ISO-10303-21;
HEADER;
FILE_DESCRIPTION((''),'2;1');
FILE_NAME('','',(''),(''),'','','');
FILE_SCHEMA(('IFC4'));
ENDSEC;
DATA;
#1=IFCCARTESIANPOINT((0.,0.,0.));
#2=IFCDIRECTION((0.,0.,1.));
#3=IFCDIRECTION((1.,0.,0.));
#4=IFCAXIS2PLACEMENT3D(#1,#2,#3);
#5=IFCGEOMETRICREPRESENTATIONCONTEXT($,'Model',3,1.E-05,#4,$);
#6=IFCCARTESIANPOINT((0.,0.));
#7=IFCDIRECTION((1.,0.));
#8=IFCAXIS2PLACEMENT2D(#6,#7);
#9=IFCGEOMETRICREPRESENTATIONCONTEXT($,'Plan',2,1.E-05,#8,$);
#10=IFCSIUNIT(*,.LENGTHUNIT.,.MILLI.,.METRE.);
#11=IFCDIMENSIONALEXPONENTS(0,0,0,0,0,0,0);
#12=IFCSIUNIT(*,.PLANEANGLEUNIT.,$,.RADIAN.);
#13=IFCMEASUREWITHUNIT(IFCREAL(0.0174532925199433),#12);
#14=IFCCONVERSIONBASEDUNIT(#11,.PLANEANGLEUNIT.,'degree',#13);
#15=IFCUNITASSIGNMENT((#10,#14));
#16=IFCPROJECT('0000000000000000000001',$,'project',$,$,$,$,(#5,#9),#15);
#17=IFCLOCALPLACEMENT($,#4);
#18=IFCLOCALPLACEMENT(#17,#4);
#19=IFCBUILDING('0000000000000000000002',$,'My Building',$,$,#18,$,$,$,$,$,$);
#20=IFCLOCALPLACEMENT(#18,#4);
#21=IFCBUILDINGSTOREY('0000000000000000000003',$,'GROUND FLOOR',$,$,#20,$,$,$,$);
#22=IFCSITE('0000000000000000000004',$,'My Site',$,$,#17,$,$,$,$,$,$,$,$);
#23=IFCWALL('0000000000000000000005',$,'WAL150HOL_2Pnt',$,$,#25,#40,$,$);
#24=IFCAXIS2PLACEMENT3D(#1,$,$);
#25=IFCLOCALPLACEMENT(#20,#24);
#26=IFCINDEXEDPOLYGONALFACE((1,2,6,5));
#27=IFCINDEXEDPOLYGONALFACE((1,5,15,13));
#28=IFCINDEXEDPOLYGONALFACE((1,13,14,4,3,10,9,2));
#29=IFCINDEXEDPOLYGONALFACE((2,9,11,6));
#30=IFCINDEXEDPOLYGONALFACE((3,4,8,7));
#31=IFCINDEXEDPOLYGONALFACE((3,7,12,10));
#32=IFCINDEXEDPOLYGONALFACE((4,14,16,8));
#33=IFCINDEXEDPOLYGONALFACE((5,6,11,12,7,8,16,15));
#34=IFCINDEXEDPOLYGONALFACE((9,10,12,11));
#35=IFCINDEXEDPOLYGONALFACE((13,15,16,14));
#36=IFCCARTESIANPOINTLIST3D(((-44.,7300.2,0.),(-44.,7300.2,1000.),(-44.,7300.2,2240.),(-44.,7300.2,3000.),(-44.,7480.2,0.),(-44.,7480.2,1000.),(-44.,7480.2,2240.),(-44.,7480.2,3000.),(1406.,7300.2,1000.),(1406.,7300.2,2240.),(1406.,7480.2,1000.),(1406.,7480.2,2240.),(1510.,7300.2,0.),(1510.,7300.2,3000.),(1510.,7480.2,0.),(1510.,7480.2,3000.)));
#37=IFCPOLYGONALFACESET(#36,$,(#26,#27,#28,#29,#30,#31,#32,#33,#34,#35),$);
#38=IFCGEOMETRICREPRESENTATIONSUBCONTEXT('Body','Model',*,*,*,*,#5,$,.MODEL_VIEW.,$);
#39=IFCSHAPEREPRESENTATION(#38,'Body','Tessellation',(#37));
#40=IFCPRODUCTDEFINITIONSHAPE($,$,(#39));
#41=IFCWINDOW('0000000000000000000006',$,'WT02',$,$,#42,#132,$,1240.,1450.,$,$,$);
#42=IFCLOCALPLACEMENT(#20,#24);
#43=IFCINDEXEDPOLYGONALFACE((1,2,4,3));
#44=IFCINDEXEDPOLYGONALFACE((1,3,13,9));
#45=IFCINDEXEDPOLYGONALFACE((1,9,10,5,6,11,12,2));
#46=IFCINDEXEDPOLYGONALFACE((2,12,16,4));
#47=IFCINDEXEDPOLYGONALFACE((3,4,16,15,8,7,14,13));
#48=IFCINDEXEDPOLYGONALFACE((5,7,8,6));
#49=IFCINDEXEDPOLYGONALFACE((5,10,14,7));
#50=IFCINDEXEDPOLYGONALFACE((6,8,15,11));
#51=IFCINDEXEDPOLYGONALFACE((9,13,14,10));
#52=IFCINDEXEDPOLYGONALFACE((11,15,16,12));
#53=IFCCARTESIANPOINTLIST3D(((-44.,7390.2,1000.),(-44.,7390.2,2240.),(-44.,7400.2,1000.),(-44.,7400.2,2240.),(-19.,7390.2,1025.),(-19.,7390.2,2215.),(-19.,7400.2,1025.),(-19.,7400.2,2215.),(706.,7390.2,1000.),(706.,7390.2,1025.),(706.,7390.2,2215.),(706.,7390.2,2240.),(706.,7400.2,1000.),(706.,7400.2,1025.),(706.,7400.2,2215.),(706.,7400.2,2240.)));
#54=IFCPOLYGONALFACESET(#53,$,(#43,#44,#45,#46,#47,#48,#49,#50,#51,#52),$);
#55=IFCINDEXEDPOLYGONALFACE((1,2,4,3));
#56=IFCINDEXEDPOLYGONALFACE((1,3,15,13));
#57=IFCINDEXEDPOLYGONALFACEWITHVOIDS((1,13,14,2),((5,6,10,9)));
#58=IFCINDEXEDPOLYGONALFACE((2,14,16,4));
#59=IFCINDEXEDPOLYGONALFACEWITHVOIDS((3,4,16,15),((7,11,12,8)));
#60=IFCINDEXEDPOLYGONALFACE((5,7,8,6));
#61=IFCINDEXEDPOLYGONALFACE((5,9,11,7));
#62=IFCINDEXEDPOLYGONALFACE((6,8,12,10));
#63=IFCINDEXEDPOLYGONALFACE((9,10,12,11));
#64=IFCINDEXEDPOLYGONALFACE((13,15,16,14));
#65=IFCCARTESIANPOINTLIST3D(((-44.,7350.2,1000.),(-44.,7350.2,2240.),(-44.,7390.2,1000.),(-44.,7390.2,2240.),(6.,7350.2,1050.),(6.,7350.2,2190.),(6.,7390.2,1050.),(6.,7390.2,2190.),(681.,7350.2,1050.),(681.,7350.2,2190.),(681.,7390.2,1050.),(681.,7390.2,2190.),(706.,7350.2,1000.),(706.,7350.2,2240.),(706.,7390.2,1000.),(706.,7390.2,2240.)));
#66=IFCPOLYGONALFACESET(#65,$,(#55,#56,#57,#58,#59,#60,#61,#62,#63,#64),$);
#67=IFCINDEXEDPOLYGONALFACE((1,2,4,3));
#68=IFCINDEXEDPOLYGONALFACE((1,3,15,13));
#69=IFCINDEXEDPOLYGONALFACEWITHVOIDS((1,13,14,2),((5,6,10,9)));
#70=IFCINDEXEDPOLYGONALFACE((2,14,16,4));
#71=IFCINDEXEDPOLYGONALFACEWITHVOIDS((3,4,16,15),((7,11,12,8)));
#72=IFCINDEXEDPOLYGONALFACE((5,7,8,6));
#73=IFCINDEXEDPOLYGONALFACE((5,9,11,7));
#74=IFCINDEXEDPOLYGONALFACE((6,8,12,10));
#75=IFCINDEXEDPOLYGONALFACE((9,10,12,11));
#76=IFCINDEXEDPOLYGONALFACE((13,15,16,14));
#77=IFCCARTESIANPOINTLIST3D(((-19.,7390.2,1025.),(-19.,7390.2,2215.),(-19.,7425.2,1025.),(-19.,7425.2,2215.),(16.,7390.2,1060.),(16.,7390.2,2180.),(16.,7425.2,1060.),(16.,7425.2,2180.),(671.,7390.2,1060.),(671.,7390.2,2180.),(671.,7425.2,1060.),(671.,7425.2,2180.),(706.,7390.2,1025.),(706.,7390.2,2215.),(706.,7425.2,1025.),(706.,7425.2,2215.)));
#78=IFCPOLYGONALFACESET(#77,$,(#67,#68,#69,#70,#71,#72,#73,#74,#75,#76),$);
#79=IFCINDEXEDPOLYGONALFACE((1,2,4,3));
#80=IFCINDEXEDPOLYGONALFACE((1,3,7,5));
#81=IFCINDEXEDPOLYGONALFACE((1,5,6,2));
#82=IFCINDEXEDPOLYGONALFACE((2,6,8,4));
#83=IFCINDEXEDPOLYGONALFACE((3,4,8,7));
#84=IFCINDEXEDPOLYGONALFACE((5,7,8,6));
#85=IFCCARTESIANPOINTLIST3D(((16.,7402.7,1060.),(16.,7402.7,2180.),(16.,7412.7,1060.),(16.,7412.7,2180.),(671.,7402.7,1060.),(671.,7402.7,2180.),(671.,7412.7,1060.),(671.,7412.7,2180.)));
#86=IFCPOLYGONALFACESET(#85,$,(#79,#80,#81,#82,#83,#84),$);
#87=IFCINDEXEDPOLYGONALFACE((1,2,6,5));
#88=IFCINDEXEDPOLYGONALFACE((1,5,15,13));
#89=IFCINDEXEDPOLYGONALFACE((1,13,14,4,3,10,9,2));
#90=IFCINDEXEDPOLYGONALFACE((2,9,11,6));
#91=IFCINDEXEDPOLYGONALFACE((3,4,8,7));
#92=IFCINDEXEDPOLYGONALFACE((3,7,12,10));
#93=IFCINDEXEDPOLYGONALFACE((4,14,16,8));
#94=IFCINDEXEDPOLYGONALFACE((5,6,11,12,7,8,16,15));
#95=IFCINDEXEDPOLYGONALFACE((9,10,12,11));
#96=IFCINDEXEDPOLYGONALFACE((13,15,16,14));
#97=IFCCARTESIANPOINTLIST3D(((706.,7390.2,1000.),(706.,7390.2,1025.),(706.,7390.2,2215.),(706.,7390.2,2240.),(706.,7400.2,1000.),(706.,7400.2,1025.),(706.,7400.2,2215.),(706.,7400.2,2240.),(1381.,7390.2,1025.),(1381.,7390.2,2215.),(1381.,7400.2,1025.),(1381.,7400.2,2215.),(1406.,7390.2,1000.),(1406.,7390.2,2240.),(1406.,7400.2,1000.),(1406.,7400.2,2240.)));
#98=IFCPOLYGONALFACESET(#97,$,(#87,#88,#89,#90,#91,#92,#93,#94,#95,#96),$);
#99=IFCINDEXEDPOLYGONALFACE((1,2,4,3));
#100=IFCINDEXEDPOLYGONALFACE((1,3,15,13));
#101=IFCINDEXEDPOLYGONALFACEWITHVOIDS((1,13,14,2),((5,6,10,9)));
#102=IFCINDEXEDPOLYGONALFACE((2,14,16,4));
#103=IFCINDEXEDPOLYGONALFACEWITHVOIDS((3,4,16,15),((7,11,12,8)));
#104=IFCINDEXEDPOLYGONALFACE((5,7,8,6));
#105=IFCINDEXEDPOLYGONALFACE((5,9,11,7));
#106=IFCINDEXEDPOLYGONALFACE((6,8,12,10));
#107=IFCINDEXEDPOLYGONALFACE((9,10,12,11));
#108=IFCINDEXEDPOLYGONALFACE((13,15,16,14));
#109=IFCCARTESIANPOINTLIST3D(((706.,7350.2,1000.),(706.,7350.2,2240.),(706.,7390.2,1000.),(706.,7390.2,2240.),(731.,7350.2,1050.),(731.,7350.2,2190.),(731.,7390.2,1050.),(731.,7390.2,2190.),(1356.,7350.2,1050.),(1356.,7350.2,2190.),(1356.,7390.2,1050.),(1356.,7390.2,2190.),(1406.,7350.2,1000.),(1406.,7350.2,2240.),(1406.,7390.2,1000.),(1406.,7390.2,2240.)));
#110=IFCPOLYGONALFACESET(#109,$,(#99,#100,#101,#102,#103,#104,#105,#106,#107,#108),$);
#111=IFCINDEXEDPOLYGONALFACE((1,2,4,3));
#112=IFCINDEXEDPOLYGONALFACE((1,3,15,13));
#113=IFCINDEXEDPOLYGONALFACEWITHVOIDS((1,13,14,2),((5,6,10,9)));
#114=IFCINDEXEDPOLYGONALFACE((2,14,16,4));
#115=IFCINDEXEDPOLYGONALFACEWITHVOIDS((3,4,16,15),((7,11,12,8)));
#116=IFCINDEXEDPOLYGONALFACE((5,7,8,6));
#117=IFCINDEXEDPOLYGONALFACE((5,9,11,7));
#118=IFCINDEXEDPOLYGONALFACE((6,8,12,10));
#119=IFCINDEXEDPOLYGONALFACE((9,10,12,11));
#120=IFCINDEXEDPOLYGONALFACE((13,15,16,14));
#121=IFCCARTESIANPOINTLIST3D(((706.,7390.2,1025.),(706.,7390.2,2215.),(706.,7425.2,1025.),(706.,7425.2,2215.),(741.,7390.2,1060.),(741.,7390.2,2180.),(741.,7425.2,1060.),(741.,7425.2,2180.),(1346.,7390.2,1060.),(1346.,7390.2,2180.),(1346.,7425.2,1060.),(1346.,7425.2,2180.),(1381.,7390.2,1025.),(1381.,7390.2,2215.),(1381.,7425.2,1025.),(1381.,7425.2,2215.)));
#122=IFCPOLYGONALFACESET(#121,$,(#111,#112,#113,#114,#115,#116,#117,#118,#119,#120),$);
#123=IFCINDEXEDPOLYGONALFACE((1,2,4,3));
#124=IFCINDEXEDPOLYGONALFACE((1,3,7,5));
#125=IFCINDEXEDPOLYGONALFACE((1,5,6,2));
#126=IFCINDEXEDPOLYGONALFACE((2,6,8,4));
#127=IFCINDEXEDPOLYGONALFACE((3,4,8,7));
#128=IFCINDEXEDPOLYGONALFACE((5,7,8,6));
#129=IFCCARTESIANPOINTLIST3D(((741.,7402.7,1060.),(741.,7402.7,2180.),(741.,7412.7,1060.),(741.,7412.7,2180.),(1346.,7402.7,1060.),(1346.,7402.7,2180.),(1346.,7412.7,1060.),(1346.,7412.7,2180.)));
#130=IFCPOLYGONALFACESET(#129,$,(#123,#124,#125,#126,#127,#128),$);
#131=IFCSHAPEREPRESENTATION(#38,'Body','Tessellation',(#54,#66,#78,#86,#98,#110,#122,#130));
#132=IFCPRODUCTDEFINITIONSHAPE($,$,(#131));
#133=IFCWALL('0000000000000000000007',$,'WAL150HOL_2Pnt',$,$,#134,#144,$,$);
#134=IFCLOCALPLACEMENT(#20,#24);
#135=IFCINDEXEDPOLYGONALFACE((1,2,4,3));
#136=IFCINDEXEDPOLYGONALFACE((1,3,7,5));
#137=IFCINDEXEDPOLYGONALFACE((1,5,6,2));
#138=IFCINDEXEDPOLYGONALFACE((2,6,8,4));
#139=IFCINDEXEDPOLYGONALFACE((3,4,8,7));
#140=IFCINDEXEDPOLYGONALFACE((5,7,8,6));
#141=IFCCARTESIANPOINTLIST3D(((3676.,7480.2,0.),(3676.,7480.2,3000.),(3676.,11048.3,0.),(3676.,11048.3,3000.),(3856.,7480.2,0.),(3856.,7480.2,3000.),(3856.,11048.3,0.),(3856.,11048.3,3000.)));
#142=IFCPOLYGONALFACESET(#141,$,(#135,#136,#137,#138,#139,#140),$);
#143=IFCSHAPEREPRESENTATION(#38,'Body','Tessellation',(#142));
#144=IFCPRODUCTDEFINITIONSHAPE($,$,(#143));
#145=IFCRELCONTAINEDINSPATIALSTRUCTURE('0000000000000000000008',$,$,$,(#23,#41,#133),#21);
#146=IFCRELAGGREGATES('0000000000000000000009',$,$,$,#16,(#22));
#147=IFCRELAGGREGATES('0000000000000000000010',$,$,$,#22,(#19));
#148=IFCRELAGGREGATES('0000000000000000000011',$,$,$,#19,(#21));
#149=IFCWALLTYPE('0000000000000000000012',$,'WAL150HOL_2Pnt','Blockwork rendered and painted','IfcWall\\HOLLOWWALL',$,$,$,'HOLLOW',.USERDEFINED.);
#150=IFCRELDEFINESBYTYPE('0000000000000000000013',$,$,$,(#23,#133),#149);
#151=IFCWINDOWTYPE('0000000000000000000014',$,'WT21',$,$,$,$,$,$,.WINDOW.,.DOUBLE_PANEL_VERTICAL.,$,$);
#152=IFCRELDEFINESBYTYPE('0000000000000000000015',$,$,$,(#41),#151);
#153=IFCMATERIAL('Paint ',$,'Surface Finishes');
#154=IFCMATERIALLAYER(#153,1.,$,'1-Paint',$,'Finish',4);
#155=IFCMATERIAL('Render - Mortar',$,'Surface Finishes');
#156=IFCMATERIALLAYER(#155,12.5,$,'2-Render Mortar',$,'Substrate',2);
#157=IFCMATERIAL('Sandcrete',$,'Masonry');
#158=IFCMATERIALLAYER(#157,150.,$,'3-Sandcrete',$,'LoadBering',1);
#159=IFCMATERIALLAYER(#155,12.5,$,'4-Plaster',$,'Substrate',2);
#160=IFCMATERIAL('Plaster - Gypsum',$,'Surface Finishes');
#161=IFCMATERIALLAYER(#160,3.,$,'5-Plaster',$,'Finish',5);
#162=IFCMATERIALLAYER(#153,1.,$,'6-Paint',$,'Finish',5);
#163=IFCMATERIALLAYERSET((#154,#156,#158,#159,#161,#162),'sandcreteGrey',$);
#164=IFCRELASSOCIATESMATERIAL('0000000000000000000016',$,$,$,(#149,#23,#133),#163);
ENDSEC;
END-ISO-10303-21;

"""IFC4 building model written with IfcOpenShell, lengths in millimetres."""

from ifc_helpers import new_model, entity, si_unit, converted_unit, frame, origin_with_axes, origin_2d_with_axis, place, context, subcontext, project, spatial, line, indexed_curve, outline, extrude, shape, source, transform, mapped, material, layer, layer_set, layer_usage, type_object, type_shapes, element, fill, save


model = new_model("IFC4")

# Units and contexts
model_context = context("Model", 3, precision=1e-05, world=origin_with_axes())
plan_context = context("Plan", 2, precision=1e-05, world=origin_2d_with_axis())
body_context_1 = subcontext(model_context, "Body", "Model", "MODEL_VIEW")
body_context_2 = subcontext(plan_context, "Body", "Plan", "PLAN_VIEW")
ifc_project = project(units=[si_unit("LENGTHUNIT", "METRE", prefix="MILLI"), converted_unit("PLANEANGLEUNIT", "degree", entity("IfcReal", 0.0174532925199433), si_unit("PLANEANGLEUNIT", "RADIAN"), dimensions=[0, 0, 0, 0, 0, 0, 0])], contexts=[model_context, plan_context])

# Site, building, storey
site_placement = place(None, origin_with_axes())
site = spatial("IfcSite", under=ifc_project, at=site_placement, Name="My Site")
building_placement = place(site_placement, origin_with_axes())
building = spatial("IfcBuilding", under=site, at=building_placement, Name="My Building")
storey_placement = place(building_placement, origin_with_axes())
storey = spatial("IfcBuildingStorey", under=building, at=storey_placement, Name="GROUND FLOOR")

# Wall, opening, window
ifc_material_1 = material(Name="Paint ", Category="Surface Finishes")
ifc_layer_1 = layer(ifc_material_1, 1.0, Name="1-Paint", Category="Finish", Priority=4)
ifc_material_2 = material(Name="Render - Mortar", Category="Surface Finishes")
ifc_layer_2 = layer(ifc_material_2, 12.5, Name="2-Render Mortar", Category="Substrate", Priority=2)
ifc_material_3 = material(Name="Sandcrete", Category="Masonry")
ifc_layer_3 = layer(ifc_material_3, 150.0, Name="3-Sandcrete", Category="LoadBering", Priority=1)
ifc_layer_4 = layer(ifc_material_2, 12.5, Name="4-Plaster", Category="Substrate", Priority=2)
ifc_material_4 = material(Name="Plaster - Gypsum", Category="Surface Finishes")
ifc_layer_5 = layer(ifc_material_4, 3.0, Name="5-Plaster", Category="Finish", Priority=5)
ifc_layer_6 = layer(ifc_material_1, 1.0, Name="6-Paint", Category="Finish", Priority=5)
ifc_layer_set_1 = layer_set([ifc_layer_1, ifc_layer_2, ifc_layer_3, ifc_layer_4, ifc_layer_5, ifc_layer_6], Name="sandcreteGrey")
ifc_layer_usage_1 = layer_usage(ifc_layer_set_1, "AXIS2", "POSITIVE", 0.0)
wall_type_1 = type_object("IfcWallType", Name="WAL150HOL_2Pnt", Description="Blockwork rendered and painted", ApplicableOccurrence="IfcWall\\HOLLOWWALL", ElementType="HOLLOW", PredefinedType="USERDEFINED", material=ifc_layer_set_1)
wall_1_placement = place(storey_placement, frame((-44.0, 7300.2, 0.0), z_axis=(0.0, 0.0, 1.0), x_axis=(1.0, 0.0, 0.0)))
wall_1 = element("IfcWall", 1, at=wall_1_placement, inside=storey, type_object=wall_type_1, material=ifc_layer_usage_1, Name="WAL150HOL_2Pnt", context=body_context_1, shape_type="SweptSolid", body=[
    extrude(outline(indexed_curve([(0.0, 0.0), (0.0, 180.0), (1554.0, 180.0), (1554.0, 0.0), (0.0, 0.0)], self_intersect=False)), origin_with_axes(), (0.0, 0.0, 1.0), 3000.0),
])
shared_shape_1 = source(origin_with_axes(), body_context_1, "Body", "SweptSolid", [
    extrude(outline(indexed_curve([(0.0, 0.0), (1450.0, 0.0), (1450.0, 1240.0), (0.0, 1240.0)], segments=[line(1, 2, 3, 4, 1)])), frame((0.0, -100.0, 0.0), z_axis=(0.0, -1.0, 0.0), x_axis=(1.0, 0.0, 0.0)), (0.0, 0.0, -1.0), 388.0),
])
opening_1_placement = place(wall_1_placement, frame((0.0, 0.0, 1000.0), z_axis=(0.0, 0.0, 1.0), x_axis=(1.0, 0.0, 0.0)))
opening_1 = element("IfcOpeningElement", 2, at=opening_1_placement, cuts=wall_1, PredefinedType="OPENING", context=body_context_1, shape_type="MappedRepresentation", body=[
    mapped(shared_shape_1, transform((0.0, 0.0, 0.0), x_axis=(1.0, 0.0, 0.0), y_axis=(0.0, 1.0, 0.0), z_axis=(0.0, 0.0, 1.0), scale=1.0)),
])
window_type_1 = type_object("IfcWindowType", Name="WT21", PartitioningType="DOUBLE_PANEL_VERTICAL", PredefinedType="WINDOW")
shared_shape_2 = source(origin_with_axes(), body_context_1, "Body", "SweptSolid", [
    extrude(outline(indexed_curve([(750.0, 0.0), (0.0, 0.0), (0.0, 1240.0), (750.0, 1240.0), (750.0, 1215.0), (25.0, 1215.0), (25.0, 25.0), (750.0, 25.0)], segments=[line(1, 2, 3, 4, 5, 6, 7, 8, 1)])), frame((0.0, 90.0, 0.0), z_axis=(0.0, -1.0, 0.0), x_axis=(1.0, 0.0, 0.0)), (0.0, 0.0, -1.0), 10.0),
    extrude(outline(indexed_curve([(0.0, 0.0), (750.0, 0.0), (750.0, 1240.0), (0.0, 1240.0)], segments=[line(1, 2, 3, 4, 1)]), holes=[indexed_curve([(50.0, 50.0), (725.0, 50.0), (725.0, 1190.0), (50.0, 1190.0)], segments=[line(1, 2, 3, 4, 1)])]), frame((0.0, 50.0, 0.0), z_axis=(0.0, -1.0, 0.0), x_axis=(1.0, 0.0, 0.0)), (0.0, 0.0, -1.0), 40.0),
    extrude(outline(indexed_curve([(0.0, 0.0), (725.0, 0.0), (725.0, 1190.0), (0.0, 1190.0)], segments=[line(1, 2, 3, 4, 1)]), holes=[indexed_curve([(35.0, 35.0), (690.0, 35.0), (690.0, 1155.0), (35.0, 1155.0)], segments=[line(1, 2, 3, 4, 1)])]), frame((25.0, 90.0, 25.0), z_axis=(0.0, -1.0, 0.0), x_axis=(1.0, 0.0, 0.0)), (0.0, 0.0, -1.0), 35.0),
    extrude(outline(indexed_curve([(35.0, 35.0), (690.0, 35.0), (690.0, 1155.0), (35.0, 1155.0)], segments=[line(1, 2, 3, 4, 1)])), frame((25.0, 102.5, 25.0), z_axis=(0.0, -1.0, 0.0), x_axis=(1.0, 0.0, 0.0)), (0.0, 0.0, -1.0), 10.0),
    extrude(outline(indexed_curve([(0.0, 1240.0), (700.0, 1240.0), (700.0, 0.0), (0.0, 0.0), (0.0, 25.0), (675.0, 25.0), (675.0, 1215.0), (0.0, 1215.0)], segments=[line(1, 2, 3, 4, 5, 6, 7, 8, 1)])), frame((750.0, 90.0, 0.0), z_axis=(0.0, -1.0, 0.0), x_axis=(1.0, 0.0, 0.0)), (0.0, 0.0, -1.0), 10.0),
    extrude(outline(indexed_curve([(0.0, 0.0), (700.0, 0.0), (700.0, 1240.0), (0.0, 1240.0)], segments=[line(1, 2, 3, 4, 1)]), holes=[indexed_curve([(25.0, 50.0), (650.0, 50.0), (650.0, 1190.0), (25.0, 1190.0)], segments=[line(1, 2, 3, 4, 1)])]), frame((750.0, 50.0, 0.0), z_axis=(0.0, -1.0, 0.0), x_axis=(1.0, 0.0, 0.0)), (0.0, 0.0, -1.0), 40.0),
    extrude(outline(indexed_curve([(0.0, 0.0), (675.0, 0.0), (675.0, 1190.0), (0.0, 1190.0)], segments=[line(1, 2, 3, 4, 1)]), holes=[indexed_curve([(35.0, 35.0), (640.0, 35.0), (640.0, 1155.0), (35.0, 1155.0)], segments=[line(1, 2, 3, 4, 1)])]), frame((750.0, 90.0, 25.0), z_axis=(0.0, -1.0, 0.0), x_axis=(1.0, 0.0, 0.0)), (0.0, 0.0, -1.0), 35.0),
    extrude(outline(indexed_curve([(35.0, 35.0), (640.0, 35.0), (640.0, 1155.0), (35.0, 1155.0)], segments=[line(1, 2, 3, 4, 1)])), frame((750.0, 102.5, 25.0), z_axis=(0.0, -1.0, 0.0), x_axis=(1.0, 0.0, 0.0)), (0.0, 0.0, -1.0), 10.0),
])
shared_shape_3 = source(origin_with_axes(), body_context_2, "Body", "Curve2D", [
    entity("IfcIndexedPolyCurve", entity("IfcCartesianPointList2D", [[50.0, 50.0], [725.0, 50.0]])),
    entity("IfcIndexedPolyCurve", entity("IfcCartesianPointList2D", [[0.0, 100.0], [25.0, 100.0], [25.0, 90.0], [50.0, 90.0], [50.0, 50.0], [0.0, 50.0]]), [entity("IfcLineIndex", [1, 2, 3, 4, 5, 6, 1])]),
    entity("IfcIndexedPolyCurve", entity("IfcCartesianPointList2D", [[750.0, 100.0], [750.0, 100.0], [750.0, 90.0], [725.0, 90.0], [725.0, 50.0], [750.0, 50.0]])),
    entity("IfcIndexedPolyCurve", entity("IfcCartesianPointList2D", [[25.0, 90.0], [60.0, 90.0], [60.0, 125.0], [25.0, 125.0]]), [entity("IfcLineIndex", [1, 2, 3, 4, 1])]),
    entity("IfcIndexedPolyCurve", entity("IfcCartesianPointList2D", [[750.0, 90.0], [715.0, 90.0], [715.0, 125.0], [750.0, 125.0]]), [entity("IfcLineIndex", [1, 2, 3, 4, 1])]),
    entity("IfcIndexedPolyCurve", entity("IfcCartesianPointList2D", [[60.0, 90.0], [715.0, 90.0]])),
    entity("IfcIndexedPolyCurve", entity("IfcCartesianPointList2D", [[60.0, 125.0], [715.0, 125.0]])),
    entity("IfcIndexedPolyCurve", entity("IfcCartesianPointList2D", [[60.0, 107.5], [715.0, 107.5]])),
    entity("IfcIndexedPolyCurve", entity("IfcCartesianPointList2D", [[775.0, 50.0], [1400.0, 50.0]])),
    entity("IfcIndexedPolyCurve", entity("IfcCartesianPointList2D", [[750.0, 100.0], [750.0, 100.0], [750.0, 90.0], [775.0, 90.0], [775.0, 50.0], [750.0, 50.0]])),
    entity("IfcIndexedPolyCurve", entity("IfcCartesianPointList2D", [[1450.0, 100.0], [1425.0, 100.0], [1425.0, 90.0], [1400.0, 90.0], [1400.0, 50.0], [1450.0, 50.0]]), [entity("IfcLineIndex", [1, 2, 3, 4, 5, 6, 1])]),
    entity("IfcIndexedPolyCurve", entity("IfcCartesianPointList2D", [[750.0, 90.0], [785.0, 90.0], [785.0, 125.0], [750.0, 125.0]]), [entity("IfcLineIndex", [1, 2, 3, 4, 1])]),
    entity("IfcIndexedPolyCurve", entity("IfcCartesianPointList2D", [[1425.0, 90.0], [1390.0, 90.0], [1390.0, 125.0], [1425.0, 125.0]]), [entity("IfcLineIndex", [1, 2, 3, 4, 1])]),
    entity("IfcIndexedPolyCurve", entity("IfcCartesianPointList2D", [[785.0, 90.0], [1390.0, 90.0]])),
    entity("IfcIndexedPolyCurve", entity("IfcCartesianPointList2D", [[785.0, 125.0], [1390.0, 125.0]])),
    entity("IfcIndexedPolyCurve", entity("IfcCartesianPointList2D", [[785.0, 107.5], [1390.0, 107.5]])),
])
type_shapes(window_type_1, [shared_shape_2, shared_shape_3])
window_1_placement = place(opening_1_placement, origin_with_axes())
window_1 = element("IfcWindow", 3, at=window_1_placement, inside=storey, type_object=window_type_1, Name="WT02", OverallHeight=1240.0, OverallWidth=1450.0, shapes=[
    shape(body_context_1, "Body", "MappedRepresentation", [mapped(shared_shape_2, transform((0.0, 0.0, 0.0), x_axis=(1.0, 0.0, 0.0), y_axis=(0.0, 1.0, 0.0), z_axis=(0.0, 0.0, 1.0), scale=1.0))]),
    shape(body_context_2, "Body", "MappedRepresentation", [mapped(shared_shape_3, transform((0.0, 0.0, 0.0), x_axis=(1.0, 0.0, 0.0), y_axis=(0.0, 1.0, 0.0), z_axis=(0.0, 0.0, 1.0), scale=1.0))]),
])
fill(opening_1, window_1)

# Wall
ifc_layer_usage_2 = layer_usage(ifc_layer_set_1, "AXIS2", "POSITIVE", 0.0)
wall_2_placement = place(storey_placement, frame((3856.0, 7480.2, 0.0), z_axis=(0.0, 0.0, 1.0), x_axis=(0.0, 1.0, 0.0)))
element("IfcWall", 4, at=wall_2_placement, inside=storey, type_object=wall_type_1, material=ifc_layer_usage_2, Name="WAL150HOL_2Pnt", context=body_context_1, shape_type="SweptSolid", body=[
    extrude(outline(indexed_curve([(0.0, 0.0), (0.0, 180.0), (3568.1, 180.0), (3568.1, 0.0), (0.0, 0.0)], self_intersect=False)), origin_with_axes(), (0.0, 0.0, 1.0), 3000.0),
])

save(model, "model.ifc")
